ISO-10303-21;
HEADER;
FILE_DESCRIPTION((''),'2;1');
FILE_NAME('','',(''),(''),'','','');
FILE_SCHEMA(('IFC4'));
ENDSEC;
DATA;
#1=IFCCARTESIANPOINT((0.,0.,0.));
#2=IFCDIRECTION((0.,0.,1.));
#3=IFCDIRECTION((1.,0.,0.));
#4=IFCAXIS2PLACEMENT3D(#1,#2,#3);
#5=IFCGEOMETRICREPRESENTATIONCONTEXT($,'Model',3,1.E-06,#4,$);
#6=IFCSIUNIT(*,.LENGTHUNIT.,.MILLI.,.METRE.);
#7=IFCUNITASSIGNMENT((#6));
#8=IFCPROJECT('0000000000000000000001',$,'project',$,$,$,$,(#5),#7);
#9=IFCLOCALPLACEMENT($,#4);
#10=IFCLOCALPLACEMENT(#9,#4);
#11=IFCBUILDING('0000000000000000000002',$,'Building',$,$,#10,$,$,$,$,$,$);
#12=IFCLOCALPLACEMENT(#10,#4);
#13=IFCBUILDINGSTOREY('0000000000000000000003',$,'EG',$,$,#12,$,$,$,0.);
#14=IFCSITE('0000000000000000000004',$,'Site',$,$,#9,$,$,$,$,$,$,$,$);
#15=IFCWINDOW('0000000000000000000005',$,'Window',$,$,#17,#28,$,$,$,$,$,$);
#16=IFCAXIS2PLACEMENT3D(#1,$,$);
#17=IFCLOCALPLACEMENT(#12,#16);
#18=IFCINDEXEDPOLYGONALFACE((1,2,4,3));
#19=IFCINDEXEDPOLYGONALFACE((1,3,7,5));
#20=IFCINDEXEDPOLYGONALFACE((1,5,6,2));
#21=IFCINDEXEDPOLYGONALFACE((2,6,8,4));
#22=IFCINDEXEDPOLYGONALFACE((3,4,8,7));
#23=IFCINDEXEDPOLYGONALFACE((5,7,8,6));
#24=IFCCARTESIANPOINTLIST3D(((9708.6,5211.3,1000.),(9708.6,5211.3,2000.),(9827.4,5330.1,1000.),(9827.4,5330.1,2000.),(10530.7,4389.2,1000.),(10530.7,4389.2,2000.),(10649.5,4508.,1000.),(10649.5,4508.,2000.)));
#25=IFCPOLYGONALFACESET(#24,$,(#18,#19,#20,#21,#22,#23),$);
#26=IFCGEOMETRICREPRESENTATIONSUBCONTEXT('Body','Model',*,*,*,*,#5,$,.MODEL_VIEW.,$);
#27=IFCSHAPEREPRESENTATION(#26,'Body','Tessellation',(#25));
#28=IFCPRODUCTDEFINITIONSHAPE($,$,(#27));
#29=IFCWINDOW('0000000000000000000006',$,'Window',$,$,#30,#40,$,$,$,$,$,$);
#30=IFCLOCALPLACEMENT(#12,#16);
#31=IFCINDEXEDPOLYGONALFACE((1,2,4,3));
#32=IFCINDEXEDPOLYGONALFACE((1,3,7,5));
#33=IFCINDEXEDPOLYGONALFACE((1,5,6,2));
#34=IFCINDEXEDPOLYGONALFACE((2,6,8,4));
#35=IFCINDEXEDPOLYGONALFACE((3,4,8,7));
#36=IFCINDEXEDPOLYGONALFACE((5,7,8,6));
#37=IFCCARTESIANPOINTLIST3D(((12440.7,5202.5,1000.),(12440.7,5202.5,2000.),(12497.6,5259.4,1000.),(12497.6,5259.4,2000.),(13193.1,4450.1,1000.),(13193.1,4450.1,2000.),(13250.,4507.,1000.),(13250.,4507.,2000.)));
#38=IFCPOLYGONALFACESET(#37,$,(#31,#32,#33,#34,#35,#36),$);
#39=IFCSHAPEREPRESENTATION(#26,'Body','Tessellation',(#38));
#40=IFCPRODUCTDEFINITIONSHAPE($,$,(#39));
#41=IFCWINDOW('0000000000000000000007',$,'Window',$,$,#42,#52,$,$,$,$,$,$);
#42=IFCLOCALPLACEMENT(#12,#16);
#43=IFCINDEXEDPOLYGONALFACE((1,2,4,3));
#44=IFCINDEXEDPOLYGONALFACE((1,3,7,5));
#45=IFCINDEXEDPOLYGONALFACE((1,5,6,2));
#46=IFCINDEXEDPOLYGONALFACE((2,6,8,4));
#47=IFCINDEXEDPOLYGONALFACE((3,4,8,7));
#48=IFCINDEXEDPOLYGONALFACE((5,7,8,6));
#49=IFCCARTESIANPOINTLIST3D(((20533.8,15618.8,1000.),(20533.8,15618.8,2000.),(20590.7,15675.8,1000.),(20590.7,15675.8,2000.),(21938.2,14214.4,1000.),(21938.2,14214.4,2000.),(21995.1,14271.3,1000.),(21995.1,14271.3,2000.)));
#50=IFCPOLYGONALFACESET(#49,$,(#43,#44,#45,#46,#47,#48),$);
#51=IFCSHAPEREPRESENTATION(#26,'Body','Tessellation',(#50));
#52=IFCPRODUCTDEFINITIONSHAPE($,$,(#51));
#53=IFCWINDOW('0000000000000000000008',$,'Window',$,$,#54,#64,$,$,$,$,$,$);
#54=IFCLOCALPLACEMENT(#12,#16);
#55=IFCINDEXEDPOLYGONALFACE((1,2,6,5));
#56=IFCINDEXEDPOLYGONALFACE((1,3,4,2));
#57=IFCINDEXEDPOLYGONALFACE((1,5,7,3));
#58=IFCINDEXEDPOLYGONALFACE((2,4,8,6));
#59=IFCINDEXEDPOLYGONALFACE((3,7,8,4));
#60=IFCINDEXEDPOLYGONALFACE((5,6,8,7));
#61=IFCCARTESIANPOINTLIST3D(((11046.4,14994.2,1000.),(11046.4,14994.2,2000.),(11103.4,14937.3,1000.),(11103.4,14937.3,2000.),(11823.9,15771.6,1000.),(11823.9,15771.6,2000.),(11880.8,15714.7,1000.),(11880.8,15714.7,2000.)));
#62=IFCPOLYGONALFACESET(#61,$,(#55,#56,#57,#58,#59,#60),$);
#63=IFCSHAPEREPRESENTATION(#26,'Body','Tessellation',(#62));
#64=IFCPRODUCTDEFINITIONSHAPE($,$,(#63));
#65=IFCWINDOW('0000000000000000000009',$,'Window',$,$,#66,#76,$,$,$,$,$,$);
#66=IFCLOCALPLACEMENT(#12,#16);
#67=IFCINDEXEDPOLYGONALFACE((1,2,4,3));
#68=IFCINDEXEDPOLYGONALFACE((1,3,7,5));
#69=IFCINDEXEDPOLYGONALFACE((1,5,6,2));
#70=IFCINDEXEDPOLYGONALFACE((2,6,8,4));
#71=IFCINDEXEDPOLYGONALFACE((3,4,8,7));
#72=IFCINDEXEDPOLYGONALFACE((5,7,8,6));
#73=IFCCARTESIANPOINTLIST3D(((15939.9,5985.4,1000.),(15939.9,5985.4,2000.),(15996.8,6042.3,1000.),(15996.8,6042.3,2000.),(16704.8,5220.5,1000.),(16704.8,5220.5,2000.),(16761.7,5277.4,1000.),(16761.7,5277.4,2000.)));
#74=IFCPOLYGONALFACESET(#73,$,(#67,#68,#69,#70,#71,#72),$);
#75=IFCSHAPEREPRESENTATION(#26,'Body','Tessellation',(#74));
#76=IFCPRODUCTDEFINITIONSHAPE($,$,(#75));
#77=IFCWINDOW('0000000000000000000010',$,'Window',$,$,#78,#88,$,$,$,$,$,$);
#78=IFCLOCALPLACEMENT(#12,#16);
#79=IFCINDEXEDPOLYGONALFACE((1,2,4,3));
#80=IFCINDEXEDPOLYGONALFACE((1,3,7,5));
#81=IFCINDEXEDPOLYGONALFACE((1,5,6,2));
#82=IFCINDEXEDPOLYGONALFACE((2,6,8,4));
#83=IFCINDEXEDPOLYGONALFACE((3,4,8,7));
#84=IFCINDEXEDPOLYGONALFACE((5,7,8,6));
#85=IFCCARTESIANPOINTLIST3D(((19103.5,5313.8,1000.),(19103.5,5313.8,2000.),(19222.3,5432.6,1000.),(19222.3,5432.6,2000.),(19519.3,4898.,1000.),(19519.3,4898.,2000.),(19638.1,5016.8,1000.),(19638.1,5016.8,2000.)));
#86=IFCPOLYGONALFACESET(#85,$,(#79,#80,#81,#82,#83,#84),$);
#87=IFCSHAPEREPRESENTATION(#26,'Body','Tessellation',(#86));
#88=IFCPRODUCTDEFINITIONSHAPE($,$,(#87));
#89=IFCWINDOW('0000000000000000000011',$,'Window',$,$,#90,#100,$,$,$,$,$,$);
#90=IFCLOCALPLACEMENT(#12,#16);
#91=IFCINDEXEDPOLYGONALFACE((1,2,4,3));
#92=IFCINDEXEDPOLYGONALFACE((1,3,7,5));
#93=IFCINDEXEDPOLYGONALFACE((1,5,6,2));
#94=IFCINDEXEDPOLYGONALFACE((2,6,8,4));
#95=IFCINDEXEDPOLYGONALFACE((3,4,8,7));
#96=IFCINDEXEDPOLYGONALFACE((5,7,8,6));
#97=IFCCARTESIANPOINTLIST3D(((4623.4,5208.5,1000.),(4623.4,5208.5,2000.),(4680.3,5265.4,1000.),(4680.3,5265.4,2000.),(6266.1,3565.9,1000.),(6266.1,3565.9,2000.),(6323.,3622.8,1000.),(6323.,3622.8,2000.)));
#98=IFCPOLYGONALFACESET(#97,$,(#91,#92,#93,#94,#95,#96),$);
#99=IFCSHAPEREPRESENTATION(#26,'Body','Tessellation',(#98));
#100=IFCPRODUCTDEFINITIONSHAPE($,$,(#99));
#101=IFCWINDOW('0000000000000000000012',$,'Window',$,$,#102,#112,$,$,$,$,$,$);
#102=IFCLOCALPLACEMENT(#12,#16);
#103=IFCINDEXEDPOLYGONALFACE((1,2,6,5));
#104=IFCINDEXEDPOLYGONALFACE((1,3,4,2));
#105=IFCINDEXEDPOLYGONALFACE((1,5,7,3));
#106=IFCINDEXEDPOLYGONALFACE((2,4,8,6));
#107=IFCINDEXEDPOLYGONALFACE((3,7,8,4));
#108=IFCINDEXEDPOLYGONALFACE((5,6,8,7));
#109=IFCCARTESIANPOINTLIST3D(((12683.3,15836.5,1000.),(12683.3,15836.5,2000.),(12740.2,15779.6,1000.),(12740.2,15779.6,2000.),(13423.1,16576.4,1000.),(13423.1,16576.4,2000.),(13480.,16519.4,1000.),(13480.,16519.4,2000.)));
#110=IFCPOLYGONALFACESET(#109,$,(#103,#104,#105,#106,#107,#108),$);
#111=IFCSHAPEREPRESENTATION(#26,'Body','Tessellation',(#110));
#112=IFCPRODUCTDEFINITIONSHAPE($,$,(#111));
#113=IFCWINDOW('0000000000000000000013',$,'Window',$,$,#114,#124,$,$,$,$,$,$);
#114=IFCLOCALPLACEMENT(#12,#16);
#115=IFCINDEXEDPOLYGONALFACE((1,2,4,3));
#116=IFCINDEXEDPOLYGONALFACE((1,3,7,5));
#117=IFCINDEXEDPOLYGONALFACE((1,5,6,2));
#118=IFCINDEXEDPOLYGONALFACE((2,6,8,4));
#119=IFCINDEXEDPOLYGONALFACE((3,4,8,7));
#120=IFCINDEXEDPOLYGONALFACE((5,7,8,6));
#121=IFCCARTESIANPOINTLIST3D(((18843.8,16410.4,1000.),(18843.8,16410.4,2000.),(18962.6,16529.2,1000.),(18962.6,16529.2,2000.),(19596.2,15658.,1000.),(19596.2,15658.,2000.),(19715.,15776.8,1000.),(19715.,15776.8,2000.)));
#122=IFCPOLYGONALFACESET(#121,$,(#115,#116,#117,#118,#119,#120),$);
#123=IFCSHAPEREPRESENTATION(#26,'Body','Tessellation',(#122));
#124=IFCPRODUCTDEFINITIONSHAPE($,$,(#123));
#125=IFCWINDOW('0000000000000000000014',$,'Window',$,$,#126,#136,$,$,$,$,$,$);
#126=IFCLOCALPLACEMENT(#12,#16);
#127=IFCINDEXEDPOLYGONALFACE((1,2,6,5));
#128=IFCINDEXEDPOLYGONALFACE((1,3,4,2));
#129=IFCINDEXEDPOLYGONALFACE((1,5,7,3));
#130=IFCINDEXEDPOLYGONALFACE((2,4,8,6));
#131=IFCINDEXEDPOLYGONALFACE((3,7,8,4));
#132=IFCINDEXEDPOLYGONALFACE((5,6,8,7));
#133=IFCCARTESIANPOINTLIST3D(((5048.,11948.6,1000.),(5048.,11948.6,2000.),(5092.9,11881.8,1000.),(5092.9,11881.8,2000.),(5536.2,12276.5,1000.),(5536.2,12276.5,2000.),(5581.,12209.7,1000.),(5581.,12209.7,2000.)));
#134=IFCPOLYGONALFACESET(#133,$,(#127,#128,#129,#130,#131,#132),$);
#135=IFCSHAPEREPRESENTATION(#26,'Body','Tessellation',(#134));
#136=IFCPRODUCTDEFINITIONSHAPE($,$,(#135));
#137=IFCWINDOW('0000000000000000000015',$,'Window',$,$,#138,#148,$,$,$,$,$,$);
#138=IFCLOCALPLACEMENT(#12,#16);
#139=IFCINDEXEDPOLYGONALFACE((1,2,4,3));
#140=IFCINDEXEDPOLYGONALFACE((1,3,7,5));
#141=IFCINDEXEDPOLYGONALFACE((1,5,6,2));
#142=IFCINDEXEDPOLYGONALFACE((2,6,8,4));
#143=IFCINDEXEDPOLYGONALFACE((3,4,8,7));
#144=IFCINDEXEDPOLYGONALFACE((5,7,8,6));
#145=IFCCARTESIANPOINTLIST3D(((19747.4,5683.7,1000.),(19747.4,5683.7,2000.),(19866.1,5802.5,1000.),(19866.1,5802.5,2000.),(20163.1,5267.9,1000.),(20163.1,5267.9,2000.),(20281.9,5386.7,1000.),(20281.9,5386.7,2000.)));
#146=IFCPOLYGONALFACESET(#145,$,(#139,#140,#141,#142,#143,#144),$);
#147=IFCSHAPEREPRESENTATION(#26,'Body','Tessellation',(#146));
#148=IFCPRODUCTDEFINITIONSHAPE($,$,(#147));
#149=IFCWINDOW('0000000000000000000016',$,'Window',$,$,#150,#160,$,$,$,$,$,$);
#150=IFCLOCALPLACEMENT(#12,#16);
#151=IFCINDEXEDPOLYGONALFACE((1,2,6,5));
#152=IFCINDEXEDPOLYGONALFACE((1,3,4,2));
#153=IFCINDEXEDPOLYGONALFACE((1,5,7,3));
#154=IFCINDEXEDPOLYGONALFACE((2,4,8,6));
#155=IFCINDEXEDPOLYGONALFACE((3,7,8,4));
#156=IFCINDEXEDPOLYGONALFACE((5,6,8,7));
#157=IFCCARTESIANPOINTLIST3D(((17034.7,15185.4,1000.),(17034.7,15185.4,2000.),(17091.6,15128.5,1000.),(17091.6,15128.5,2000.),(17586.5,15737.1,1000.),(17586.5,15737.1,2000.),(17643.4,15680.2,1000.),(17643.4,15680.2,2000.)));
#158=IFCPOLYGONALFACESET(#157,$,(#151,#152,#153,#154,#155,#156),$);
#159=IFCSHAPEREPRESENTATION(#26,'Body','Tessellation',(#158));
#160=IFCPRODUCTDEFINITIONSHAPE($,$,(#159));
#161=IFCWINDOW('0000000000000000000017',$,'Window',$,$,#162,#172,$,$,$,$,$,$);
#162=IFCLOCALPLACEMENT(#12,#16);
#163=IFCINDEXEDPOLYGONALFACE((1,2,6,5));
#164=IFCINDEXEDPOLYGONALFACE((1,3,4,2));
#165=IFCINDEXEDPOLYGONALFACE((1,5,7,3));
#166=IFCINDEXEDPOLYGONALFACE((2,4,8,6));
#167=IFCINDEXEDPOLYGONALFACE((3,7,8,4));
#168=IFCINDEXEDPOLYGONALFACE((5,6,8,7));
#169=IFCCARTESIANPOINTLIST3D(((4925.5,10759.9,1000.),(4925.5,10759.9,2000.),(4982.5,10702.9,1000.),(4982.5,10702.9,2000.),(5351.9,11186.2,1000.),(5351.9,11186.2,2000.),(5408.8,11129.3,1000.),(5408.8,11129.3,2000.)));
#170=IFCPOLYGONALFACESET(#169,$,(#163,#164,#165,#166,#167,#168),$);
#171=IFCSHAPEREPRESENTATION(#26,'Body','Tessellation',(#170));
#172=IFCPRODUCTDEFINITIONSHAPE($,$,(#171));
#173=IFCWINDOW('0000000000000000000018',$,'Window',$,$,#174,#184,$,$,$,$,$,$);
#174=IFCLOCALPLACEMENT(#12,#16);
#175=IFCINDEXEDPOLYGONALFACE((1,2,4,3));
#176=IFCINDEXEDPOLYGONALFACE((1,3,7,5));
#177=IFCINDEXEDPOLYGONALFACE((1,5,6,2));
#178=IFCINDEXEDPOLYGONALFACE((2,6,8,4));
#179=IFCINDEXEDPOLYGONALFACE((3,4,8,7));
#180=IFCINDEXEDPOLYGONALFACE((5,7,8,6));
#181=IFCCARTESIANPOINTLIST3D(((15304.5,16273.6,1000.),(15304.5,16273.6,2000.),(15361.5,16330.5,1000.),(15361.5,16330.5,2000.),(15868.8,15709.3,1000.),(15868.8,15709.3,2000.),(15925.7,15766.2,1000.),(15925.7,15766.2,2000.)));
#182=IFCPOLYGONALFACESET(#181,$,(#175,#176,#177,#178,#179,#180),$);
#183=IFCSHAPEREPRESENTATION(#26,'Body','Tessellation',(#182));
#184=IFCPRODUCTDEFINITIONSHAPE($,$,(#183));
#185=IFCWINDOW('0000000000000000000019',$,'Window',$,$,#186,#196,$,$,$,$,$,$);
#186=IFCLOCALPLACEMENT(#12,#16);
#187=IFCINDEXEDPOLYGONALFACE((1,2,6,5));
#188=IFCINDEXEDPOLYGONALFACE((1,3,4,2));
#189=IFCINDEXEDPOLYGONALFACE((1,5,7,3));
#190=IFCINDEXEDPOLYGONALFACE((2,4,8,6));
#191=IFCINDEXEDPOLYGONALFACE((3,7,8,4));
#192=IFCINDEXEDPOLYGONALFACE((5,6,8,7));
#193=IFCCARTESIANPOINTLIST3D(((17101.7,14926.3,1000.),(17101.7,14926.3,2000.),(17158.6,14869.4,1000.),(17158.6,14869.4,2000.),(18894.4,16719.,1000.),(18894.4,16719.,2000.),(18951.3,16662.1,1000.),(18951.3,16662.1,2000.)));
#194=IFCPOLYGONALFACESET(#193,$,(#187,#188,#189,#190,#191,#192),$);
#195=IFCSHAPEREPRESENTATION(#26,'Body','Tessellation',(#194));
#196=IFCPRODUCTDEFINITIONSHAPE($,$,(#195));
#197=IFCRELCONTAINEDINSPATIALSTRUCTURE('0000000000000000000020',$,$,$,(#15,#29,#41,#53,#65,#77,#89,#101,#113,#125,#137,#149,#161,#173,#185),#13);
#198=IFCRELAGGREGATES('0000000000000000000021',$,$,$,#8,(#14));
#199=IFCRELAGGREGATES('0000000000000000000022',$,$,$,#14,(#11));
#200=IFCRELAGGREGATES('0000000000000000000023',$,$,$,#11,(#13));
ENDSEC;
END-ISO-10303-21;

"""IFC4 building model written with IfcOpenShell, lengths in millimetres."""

from ifc_helpers import new_model, si_unit, frame, origin_with_axes, place, context, subcontext, project, spatial, rectangle, extrude, element, save


model = new_model("IFC4")

# Units and contexts
model_context = context("Model", 3, precision=1e-06, world=origin_with_axes())
body_context = subcontext(model_context, "Body", "Model", "MODEL_VIEW")
ifc_project = project(units=[si_unit("LENGTHUNIT", "METRE", prefix="MILLI")], contexts=[model_context])

# Site, building, storey
site_placement = place(None, origin_with_axes())
site = spatial("IfcSite", under=ifc_project, at=site_placement, Name="Site")
building_placement = place(site_placement, origin_with_axes())
building = spatial("IfcBuilding", under=site, at=building_placement, Name="Building")
storey_placement = place(building_placement, origin_with_axes())
storey = spatial("IfcBuildingStorey", under=building, at=storey_placement, Name="EG", Elevation=0.0)

# Windows
window_1_placement = place(storey_placement, origin_with_axes())
element("IfcWindow", 1, at=window_1_placement, inside=storey, Name="Window", context=body_context, shape_type="SweptSolid", body=[
    extrude(rectangle(XDim=1162.6, YDim=168.0), frame((10179.0, 4859.7, 1000.0), z_axis=(0.0, 0.0, 1.0), x_axis=(-0.707107, 0.707107, 0.0)), (0.0, 0.0, 1.0), 1000.0),
])
window_2_placement = place(storey_placement, origin_with_axes())
element("IfcWindow", 2, at=window_2_placement, inside=storey, Name="Window", context=body_context, shape_type="SweptSolid", body=[
    extrude(rectangle(XDim=1064.0, YDim=80.5), frame((12845.3, 4854.8, 1000.0), z_axis=(0.0, 0.0, 1.0), x_axis=(-0.707107, 0.707107, 0.0)), (0.0, 0.0, 1.0), 1000.0),
])
window_3_placement = place(storey_placement, origin_with_axes())
element("IfcWindow", 3, at=window_3_placement, inside=storey, Name="Window", context=body_context, shape_type="SweptSolid", body=[
    extrude(rectangle(XDim=1986.2, YDim=80.5), frame((21264.4, 14945.1, 1000.0), z_axis=(0.0, 0.0, 1.0), x_axis=(0.707107, -0.707107, 0.0)), (0.0, 0.0, 1.0), 1000.0),
])
window_4_placement = place(storey_placement, origin_with_axes())
element("IfcWindow", 4, at=window_4_placement, inside=storey, Name="Window", context=body_context, shape_type="SweptSolid", body=[
    extrude(rectangle(XDim=1099.5, YDim=80.5), frame((11463.6, 15354.5, 1000.0), z_axis=(0.0, 0.0, 1.0), x_axis=(0.707107, 0.707107, 0.0)), (0.0, 0.0, 1.0), 1000.0),
])
window_5_placement = place(storey_placement, origin_with_axes())
element("IfcWindow", 5, at=window_5_placement, inside=storey, Name="Window", context=body_context, shape_type="SweptSolid", body=[
    extrude(rectangle(XDim=1081.7, YDim=80.5), frame((16350.8, 5631.4, 1000.0), z_axis=(0.0, 0.0, 1.0), x_axis=(0.707107, -0.707107, 0.0)), (0.0, 0.0, 1.0), 1000.0),
])
window_6_placement = place(storey_placement, origin_with_axes())
element("IfcWindow", 6, at=window_6_placement, inside=storey, Name="Window", context=body_context, shape_type="SweptSolid", body=[
    extrude(rectangle(XDim=588.0, YDim=168.0), frame((19370.8, 5165.3, 1000.0), z_axis=(0.0, 0.0, 1.0), x_axis=(-0.707107, 0.707107, 0.0)), (0.0, 0.0, 1.0), 1000.0),
])
window_7_placement = place(storey_placement, origin_with_axes())
element("IfcWindow", 7, at=window_7_placement, inside=storey, Name="Window", context=body_context, shape_type="SweptSolid", body=[
    extrude(rectangle(XDim=2323.1, YDim=80.5), frame((5473.2, 4415.6, 1000.0), z_axis=(0.0, 0.0, 1.0), x_axis=(-0.707107, 0.707107, 0.0)), (0.0, 0.0, 1.0), 1000.0),
])
window_8_placement = place(storey_placement, origin_with_axes())
element("IfcWindow", 8, at=window_8_placement, inside=storey, Name="Window", context=body_context, shape_type="SweptSolid", body=[
    extrude(rectangle(XDim=1046.3, YDim=80.5), frame((13081.7, 16178.0, 1000.0), z_axis=(0.0, 0.0, 1.0), x_axis=(-0.707107, -0.707107, 0.0)), (0.0, 0.0, 1.0), 1000.0),
])
window_9_placement = place(storey_placement, origin_with_axes())
element("IfcWindow", 9, at=window_9_placement, inside=storey, Name="Window", context=body_context, shape_type="SweptSolid", body=[
    extrude(rectangle(XDim=1064.0, YDim=168.0), frame((19279.4, 16093.6, 1000.0), z_axis=(0.0, 0.0, 1.0), x_axis=(-0.707107, 0.707107, 0.0)), (0.0, 0.0, 1.0), 1000.0),
])
window_10_placement = place(storey_placement, origin_with_axes())
element("IfcWindow", 10, at=window_10_placement, inside=storey, Name="Window", context=body_context, shape_type="SweptSolid", body=[
    extrude(rectangle(XDim=588.0, YDim=80.5), frame((5314.5, 12079.1, 1000.0), z_axis=(0.0, 0.0, 1.0), x_axis=(-0.830139, -0.557556, 0.0)), (0.0, 0.0, 1.0), 1000.0),
])
window_11_placement = place(storey_placement, origin_with_axes())
element("IfcWindow", 11, at=window_11_placement, inside=storey, Name="Window", context=body_context, shape_type="SweptSolid", body=[
    extrude(rectangle(XDim=588.0, YDim=168.0), frame((20014.6, 5535.2, 1000.0), z_axis=(0.0, 0.0, 1.0), x_axis=(0.707107, -0.707107, 0.0)), (0.0, 0.0, 1.0), 1000.0),
])
window_12_placement = place(storey_placement, origin_with_axes())
element("IfcWindow", 12, at=window_12_placement, inside=storey, Name="Window", context=body_context, shape_type="SweptSolid", body=[
    extrude(rectangle(XDim=780.3, YDim=80.5), frame((17339.0, 15432.8, 1000.0), z_axis=(0.0, 0.0, 1.0), x_axis=(0.707107, 0.707107, 0.0)), (0.0, 0.0, 1.0), 1000.0),
])
window_13_placement = place(storey_placement, origin_with_axes())
element("IfcWindow", 13, at=window_13_placement, inside=storey, Name="Window", context=body_context, shape_type="SweptSolid", body=[
    extrude(rectangle(XDim=602.9, YDim=80.5), frame((5167.2, 10944.6, 1000.0), z_axis=(0.0, 0.0, 1.0), x_axis=(0.707107, 0.707107, 0.0)), (0.0, 0.0, 1.0), 1000.0),
])
window_14_placement = place(storey_placement, origin_with_axes())
element("IfcWindow", 14, at=window_14_placement, inside=storey, Name="Window", context=body_context, shape_type="SweptSolid", body=[
    extrude(rectangle(XDim=798.0, YDim=80.5), frame((15615.1, 16019.9, 1000.0), z_axis=(0.0, 0.0, 1.0), x_axis=(-0.707107, 0.707107, 0.0)), (0.0, 0.0, 1.0), 1000.0),
])
window_15_placement = place(storey_placement, origin_with_axes())
element("IfcWindow", 15, at=window_15_placement, inside=storey, Name="Window", context=body_context, shape_type="SweptSolid", body=[
    extrude(rectangle(XDim=2535.2, YDim=80.5), frame((18026.5, 15794.2, 1000.0), z_axis=(0.0, 0.0, 1.0), x_axis=(0.707107, 0.707107, 0.0)), (0.0, 0.0, 1.0), 1000.0),
])

save(model, "model.ifc")
